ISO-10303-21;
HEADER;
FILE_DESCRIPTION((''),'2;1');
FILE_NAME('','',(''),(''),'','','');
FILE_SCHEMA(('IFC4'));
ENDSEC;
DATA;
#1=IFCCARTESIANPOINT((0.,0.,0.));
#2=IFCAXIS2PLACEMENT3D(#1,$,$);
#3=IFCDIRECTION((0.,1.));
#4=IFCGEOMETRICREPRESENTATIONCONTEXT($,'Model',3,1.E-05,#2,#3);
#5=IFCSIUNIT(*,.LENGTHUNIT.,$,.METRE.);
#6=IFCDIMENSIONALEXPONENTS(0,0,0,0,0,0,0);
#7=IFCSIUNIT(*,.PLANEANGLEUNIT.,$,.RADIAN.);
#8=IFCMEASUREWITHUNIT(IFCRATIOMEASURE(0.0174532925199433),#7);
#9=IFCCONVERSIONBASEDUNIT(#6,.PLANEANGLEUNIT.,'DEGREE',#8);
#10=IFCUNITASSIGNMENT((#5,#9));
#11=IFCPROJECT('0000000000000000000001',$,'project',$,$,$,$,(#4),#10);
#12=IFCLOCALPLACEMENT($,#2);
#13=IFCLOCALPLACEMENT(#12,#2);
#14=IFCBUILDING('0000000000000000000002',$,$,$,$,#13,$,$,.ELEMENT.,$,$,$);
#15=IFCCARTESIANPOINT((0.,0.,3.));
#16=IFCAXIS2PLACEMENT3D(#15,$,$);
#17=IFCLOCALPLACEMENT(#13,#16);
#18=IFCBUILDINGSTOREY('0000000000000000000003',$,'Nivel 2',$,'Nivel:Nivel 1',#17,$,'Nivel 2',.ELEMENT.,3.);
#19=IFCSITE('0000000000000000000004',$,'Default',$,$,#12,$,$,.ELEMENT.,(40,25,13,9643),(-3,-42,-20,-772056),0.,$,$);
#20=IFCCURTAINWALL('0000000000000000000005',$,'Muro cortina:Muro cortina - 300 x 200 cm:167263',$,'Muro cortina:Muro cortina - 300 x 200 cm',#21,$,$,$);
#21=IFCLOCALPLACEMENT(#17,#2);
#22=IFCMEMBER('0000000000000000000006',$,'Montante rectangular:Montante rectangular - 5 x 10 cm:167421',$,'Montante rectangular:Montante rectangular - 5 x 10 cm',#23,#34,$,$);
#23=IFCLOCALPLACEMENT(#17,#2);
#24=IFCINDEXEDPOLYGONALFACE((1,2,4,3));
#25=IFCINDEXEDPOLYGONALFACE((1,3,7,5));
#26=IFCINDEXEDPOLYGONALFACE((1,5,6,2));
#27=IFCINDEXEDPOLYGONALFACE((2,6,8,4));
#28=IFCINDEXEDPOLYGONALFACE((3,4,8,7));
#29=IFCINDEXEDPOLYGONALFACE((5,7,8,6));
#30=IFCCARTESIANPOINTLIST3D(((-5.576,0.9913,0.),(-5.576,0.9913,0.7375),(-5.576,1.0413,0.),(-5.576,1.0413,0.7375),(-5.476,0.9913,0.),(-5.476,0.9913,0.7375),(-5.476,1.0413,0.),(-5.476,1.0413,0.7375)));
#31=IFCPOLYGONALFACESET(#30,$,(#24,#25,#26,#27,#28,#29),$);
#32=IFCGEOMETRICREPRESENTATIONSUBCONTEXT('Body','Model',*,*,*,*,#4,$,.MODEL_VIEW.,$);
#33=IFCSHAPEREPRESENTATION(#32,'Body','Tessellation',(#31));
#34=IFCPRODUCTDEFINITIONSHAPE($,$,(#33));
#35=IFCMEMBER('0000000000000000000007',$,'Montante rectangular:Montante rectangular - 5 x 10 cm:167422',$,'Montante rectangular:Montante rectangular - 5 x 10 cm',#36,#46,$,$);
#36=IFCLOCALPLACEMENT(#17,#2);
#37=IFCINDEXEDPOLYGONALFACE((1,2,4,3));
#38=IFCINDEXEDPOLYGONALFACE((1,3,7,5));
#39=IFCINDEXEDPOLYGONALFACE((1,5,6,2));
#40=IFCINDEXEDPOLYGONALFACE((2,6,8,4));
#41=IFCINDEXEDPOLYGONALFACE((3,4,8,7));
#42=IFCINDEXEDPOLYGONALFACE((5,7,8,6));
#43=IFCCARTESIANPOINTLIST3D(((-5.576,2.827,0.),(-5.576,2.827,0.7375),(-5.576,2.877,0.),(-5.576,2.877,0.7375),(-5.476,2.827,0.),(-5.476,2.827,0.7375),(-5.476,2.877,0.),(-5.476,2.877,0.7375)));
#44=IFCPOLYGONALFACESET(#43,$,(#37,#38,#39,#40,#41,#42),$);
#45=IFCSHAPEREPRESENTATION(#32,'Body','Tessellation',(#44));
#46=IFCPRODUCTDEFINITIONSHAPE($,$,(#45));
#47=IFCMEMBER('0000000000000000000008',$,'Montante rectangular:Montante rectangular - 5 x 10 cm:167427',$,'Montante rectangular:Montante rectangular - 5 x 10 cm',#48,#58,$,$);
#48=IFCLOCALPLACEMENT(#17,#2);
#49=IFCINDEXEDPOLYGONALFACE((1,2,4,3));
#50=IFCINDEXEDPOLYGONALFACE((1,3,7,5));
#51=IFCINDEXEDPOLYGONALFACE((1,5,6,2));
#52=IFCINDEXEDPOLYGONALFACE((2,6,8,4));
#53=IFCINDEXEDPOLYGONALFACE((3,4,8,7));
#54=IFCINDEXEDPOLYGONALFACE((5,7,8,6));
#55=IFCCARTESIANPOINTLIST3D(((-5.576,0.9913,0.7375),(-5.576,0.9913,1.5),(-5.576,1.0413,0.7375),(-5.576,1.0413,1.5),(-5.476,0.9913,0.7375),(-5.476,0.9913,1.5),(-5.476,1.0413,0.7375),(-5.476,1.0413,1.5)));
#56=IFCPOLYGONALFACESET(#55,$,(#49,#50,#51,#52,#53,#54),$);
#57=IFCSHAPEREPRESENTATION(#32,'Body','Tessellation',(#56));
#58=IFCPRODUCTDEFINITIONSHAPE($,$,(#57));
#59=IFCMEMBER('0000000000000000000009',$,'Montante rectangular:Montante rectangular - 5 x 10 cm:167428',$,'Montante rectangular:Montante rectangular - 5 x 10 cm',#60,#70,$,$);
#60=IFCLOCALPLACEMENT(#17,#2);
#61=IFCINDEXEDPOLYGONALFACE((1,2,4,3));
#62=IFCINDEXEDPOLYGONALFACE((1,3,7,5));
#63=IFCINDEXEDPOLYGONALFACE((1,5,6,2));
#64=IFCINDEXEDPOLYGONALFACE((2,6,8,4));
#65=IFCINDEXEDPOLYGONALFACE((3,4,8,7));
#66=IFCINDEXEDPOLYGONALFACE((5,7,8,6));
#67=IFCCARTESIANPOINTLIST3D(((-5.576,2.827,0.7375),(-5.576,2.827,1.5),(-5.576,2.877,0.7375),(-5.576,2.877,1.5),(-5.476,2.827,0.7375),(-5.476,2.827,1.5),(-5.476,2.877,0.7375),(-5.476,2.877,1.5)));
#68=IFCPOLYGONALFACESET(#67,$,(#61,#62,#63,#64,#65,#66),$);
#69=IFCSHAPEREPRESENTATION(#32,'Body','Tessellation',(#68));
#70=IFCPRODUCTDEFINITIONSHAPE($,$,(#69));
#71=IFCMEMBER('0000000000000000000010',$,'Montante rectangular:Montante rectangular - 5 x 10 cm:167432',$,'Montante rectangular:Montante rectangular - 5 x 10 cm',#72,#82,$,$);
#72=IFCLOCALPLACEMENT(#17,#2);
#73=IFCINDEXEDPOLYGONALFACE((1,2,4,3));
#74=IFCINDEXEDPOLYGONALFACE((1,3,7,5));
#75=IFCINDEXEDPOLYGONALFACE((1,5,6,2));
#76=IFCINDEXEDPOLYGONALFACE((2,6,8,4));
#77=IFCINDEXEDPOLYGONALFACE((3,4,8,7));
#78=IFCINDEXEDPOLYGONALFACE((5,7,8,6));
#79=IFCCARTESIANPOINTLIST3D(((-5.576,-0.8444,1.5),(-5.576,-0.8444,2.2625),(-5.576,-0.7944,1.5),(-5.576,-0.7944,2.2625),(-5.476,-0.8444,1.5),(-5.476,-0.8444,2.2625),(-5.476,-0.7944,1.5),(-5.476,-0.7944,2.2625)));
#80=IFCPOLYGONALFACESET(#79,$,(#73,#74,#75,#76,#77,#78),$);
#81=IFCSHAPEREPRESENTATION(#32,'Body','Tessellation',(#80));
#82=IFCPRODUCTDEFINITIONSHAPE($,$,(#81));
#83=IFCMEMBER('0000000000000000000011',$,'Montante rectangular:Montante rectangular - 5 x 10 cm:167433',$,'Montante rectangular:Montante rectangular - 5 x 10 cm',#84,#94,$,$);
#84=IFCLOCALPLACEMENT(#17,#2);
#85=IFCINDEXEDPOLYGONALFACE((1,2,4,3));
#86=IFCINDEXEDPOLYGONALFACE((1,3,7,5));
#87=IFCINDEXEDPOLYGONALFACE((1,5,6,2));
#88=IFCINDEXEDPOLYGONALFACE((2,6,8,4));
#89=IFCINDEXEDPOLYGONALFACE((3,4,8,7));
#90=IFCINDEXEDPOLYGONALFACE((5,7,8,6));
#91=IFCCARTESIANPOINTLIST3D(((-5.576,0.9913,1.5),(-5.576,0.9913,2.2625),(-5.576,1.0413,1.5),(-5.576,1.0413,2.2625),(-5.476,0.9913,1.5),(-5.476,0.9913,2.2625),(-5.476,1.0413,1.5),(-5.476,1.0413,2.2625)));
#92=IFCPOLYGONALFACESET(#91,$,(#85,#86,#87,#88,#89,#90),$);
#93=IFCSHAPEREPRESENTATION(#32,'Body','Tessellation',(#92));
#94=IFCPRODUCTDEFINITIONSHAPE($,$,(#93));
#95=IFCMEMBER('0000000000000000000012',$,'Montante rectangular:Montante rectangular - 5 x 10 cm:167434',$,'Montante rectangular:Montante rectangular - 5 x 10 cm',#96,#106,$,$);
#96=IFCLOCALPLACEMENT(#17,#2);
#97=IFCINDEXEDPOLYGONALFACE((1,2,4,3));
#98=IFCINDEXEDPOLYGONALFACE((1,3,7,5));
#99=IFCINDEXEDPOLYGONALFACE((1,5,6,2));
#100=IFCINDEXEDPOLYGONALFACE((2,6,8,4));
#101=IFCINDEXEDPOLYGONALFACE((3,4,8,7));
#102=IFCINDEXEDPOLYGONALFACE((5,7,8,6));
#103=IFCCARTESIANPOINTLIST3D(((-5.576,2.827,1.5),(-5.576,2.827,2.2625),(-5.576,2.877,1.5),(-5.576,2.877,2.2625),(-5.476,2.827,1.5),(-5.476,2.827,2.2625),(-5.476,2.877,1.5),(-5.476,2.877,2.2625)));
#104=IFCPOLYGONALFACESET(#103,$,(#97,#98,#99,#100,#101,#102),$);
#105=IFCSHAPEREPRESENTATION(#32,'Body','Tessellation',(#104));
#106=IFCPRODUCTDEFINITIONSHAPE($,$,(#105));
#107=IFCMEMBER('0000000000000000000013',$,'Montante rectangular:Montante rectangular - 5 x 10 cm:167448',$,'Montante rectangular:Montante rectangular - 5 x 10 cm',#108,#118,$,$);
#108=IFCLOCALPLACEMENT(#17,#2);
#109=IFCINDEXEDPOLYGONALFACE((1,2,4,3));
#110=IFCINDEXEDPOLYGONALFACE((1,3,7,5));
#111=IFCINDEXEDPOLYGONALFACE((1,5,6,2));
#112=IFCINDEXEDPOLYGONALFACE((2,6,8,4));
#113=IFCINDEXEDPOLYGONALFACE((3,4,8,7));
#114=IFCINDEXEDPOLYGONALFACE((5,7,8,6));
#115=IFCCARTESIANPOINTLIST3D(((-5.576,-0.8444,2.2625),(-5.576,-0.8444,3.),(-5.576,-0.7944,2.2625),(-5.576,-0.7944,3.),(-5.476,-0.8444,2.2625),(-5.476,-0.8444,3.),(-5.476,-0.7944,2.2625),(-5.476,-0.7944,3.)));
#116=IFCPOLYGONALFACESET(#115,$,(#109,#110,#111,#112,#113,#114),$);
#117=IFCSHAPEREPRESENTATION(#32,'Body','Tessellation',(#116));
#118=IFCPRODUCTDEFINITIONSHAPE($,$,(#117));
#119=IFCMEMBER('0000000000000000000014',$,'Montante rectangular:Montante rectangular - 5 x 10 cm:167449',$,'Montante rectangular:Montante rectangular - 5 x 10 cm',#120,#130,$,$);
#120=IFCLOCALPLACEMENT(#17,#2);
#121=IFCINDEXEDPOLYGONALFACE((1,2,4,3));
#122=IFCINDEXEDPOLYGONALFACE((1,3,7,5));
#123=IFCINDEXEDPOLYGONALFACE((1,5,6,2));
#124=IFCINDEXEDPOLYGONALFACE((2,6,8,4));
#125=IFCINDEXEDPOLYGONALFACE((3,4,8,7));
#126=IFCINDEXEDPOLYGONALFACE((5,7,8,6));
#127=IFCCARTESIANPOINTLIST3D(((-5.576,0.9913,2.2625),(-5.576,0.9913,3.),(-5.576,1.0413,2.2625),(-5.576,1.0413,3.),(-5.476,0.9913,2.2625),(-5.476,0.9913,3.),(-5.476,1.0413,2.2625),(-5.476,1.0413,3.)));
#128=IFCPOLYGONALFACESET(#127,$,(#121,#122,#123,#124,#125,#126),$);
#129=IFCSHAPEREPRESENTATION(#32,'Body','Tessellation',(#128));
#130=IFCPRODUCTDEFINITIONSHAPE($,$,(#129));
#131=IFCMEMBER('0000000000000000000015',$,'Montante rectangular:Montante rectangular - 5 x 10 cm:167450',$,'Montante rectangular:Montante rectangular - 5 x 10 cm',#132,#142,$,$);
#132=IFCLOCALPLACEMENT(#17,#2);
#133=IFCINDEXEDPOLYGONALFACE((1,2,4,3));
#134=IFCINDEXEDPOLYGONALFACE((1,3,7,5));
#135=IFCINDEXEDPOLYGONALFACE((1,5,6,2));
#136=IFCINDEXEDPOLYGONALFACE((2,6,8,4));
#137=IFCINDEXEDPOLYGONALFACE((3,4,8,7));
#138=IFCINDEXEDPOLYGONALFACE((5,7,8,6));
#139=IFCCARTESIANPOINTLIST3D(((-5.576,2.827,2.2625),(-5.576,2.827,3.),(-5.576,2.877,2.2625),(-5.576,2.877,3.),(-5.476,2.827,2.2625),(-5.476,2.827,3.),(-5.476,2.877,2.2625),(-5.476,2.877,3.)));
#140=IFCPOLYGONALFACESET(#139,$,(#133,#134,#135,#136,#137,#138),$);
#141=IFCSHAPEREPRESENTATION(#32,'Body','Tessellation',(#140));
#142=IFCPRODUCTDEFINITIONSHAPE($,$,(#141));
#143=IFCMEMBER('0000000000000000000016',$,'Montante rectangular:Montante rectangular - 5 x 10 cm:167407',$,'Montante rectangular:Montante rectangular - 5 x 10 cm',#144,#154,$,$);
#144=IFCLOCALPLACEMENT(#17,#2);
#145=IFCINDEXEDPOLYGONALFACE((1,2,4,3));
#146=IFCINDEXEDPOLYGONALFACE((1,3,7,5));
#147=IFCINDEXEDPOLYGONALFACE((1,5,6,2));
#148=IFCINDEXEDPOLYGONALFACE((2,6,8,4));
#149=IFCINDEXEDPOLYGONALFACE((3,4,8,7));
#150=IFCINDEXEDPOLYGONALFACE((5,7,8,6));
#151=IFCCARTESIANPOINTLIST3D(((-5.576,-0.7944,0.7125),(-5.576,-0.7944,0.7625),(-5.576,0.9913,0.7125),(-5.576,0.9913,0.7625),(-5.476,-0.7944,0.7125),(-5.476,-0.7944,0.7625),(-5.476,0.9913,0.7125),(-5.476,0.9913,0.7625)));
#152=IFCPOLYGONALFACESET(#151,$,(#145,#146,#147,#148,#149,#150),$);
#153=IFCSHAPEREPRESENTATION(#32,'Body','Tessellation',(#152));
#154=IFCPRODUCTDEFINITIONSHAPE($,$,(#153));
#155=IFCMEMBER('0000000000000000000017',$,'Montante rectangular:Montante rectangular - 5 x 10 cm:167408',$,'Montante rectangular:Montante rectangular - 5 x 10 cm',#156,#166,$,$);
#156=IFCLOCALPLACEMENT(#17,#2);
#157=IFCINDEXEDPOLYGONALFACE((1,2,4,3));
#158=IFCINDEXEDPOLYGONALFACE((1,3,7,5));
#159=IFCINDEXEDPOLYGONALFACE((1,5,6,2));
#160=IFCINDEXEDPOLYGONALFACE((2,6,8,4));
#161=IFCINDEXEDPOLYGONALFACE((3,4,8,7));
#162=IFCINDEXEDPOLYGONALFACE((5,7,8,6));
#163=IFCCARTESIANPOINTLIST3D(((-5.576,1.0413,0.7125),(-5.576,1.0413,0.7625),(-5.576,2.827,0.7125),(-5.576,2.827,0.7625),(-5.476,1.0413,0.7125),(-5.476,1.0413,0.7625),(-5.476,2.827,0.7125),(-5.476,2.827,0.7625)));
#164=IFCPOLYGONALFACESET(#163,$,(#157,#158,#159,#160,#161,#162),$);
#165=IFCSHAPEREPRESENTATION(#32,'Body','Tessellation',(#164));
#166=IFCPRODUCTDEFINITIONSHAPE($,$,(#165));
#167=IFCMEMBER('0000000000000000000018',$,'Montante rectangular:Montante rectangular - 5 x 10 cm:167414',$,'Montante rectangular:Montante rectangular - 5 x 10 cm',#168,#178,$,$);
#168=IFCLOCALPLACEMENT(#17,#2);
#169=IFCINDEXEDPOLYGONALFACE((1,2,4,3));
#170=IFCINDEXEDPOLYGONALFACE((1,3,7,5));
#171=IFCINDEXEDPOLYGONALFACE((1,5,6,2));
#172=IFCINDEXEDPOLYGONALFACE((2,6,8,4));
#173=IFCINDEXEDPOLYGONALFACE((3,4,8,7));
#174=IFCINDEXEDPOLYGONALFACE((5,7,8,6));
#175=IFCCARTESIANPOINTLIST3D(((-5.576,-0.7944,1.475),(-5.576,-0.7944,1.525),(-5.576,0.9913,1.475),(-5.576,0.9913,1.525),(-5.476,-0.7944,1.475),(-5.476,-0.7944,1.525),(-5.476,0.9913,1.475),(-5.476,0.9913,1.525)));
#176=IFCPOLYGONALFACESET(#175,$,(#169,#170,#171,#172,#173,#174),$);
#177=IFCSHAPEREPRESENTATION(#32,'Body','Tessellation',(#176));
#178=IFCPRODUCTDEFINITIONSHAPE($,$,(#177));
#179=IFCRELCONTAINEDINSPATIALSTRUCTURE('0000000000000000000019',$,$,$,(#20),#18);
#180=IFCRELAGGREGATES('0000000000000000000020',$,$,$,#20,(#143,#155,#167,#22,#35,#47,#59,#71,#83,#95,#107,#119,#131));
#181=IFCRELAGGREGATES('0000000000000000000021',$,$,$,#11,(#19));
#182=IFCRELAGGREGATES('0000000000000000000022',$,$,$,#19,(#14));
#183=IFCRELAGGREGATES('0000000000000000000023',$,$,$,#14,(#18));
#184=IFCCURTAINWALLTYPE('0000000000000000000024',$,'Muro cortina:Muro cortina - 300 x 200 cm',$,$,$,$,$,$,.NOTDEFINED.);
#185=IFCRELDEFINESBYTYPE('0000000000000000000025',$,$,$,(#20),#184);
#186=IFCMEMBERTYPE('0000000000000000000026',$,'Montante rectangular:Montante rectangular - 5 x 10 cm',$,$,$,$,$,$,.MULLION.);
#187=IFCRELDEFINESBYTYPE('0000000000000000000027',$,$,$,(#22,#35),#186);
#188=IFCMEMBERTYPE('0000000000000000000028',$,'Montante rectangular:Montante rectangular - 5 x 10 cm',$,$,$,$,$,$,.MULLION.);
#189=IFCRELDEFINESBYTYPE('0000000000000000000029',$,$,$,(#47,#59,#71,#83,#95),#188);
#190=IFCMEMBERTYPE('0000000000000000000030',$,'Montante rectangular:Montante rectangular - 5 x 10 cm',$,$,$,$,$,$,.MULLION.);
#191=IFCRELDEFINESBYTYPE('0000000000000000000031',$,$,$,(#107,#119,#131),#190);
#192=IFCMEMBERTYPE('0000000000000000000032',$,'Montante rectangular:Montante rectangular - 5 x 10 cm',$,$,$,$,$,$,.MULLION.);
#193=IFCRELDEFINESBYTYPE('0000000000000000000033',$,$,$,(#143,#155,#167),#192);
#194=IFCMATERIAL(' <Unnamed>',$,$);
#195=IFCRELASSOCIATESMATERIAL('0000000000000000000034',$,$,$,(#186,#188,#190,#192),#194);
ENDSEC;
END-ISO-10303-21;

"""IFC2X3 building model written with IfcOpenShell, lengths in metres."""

from ifc_helpers import new_model, entity, si_unit, converted_unit, direction, frame, origin, origin_2d_with_axis, place, context, subcontext, project, spatial, rectangle, extrude, source, transform, mapped, material, type_object, type_shapes, element, aggregate, save


model = new_model("IFC2X3")

# Units and contexts
model_context = context("Model", 3, precision=1e-05, world=origin(), true_north=direction((0.0, 1.0)))
body_context = subcontext(model_context, "Body", "Model", "MODEL_VIEW")
ifc_project = project(units=[si_unit("LENGTHUNIT", "METRE"), converted_unit("PLANEANGLEUNIT", "DEGREE", entity("IfcRatioMeasure", 0.0174532925199433), si_unit("PLANEANGLEUNIT", "RADIAN"), dimensions=[0, 0, 0, 0, 0, 0, 0])], contexts=[model_context])

# Site, building, storey
site_placement = place(None, origin())
site = spatial("IfcSite", under=ifc_project, at=site_placement, Name="Default", CompositionType="ELEMENT", RefLatitude=(40, 25, 13, 9643), RefLongitude=(-3, -42, -20, -772056), RefElevation=0.0)
building_placement = place(site_placement, origin())
building = spatial("IfcBuilding", under=site, at=building_placement, CompositionType="ELEMENT")
storey_placement = place(building_placement, frame((0.0, 0.0, 3.0)))
storey = spatial("IfcBuildingStorey", under=building, at=storey_placement, Name="Nivel 2", ObjectType="Nivel:Nivel 1", LongName="Nivel 2", CompositionType="ELEMENT", Elevation=3.0)

# Curtain wall, members
curtain_wall_type = type_object("IfcCurtainWallType", Name="Muro cortina:Muro cortina - 300 x 200 cm", PredefinedType="NOTDEFINED")
curtain_wall_placement = place(storey_placement, frame((0.0, 0.0, -3.0)))
curtain_wall = element("IfcCurtainWall", 1, at=curtain_wall_placement, inside=storey, type_object=curtain_wall_type, Name="Muro cortina:Muro cortina - 300 x 200 cm:167263", ObjectType="Muro cortina:Muro cortina - 300 x 200 cm")
ifc_material_1 = material(Name=" <Unnamed>")
member_type_1 = type_object("IfcMemberType", Name="Montante rectangular:Montante rectangular - 5 x 10 cm", PredefinedType="MULLION", material=ifc_material_1)
shared_shape_1 = source(origin(), body_context, "Body", "SweptSolid", [
    extrude(rectangle(XDim=0.1, YDim=0.05, at=origin_2d_with_axis()), frame((0.0, 0.0, -0.7375), z_axis=(0.0, 0.0, 1.0), x_axis=(0.0, -1.0, 0.0)), (0.0, 0.0, 1.0), 0.7375),
])
type_shapes(member_type_1, [shared_shape_1])
member_1_placement = place(storey_placement, frame((-5.526, 1.0163, 0.0), z_axis=(0.0, 0.0, -1.0), x_axis=(0.0, 1.0, 0.0)))
member_1 = element("IfcMember", 2, at=member_1_placement, type_object=member_type_1, Name="Montante rectangular:Montante rectangular - 5 x 10 cm:167421", ObjectType="Montante rectangular:Montante rectangular - 5 x 10 cm", context=body_context, shape_type="MappedRepresentation", body=[
    mapped(shared_shape_1, transform((0.0, 0.0, 0.0), scale=1.0)),
])
member_2_placement = place(storey_placement, frame((-5.526, 2.852, 0.0), z_axis=(0.0, 0.0, -1.0), x_axis=(0.0, 1.0, 0.0)))
member_2 = element("IfcMember", 3, at=member_2_placement, type_object=member_type_1, Name="Montante rectangular:Montante rectangular - 5 x 10 cm:167422", ObjectType="Montante rectangular:Montante rectangular - 5 x 10 cm", context=body_context, shape_type="MappedRepresentation", body=[
    mapped(shared_shape_1, transform((0.0, 0.0, 0.0), scale=1.0)),
])
member_type_2 = type_object("IfcMemberType", Name="Montante rectangular:Montante rectangular - 5 x 10 cm", PredefinedType="MULLION", material=ifc_material_1)
shared_shape_2 = source(origin(), body_context, "Body", "SweptSolid", [
    extrude(rectangle(XDim=0.1, YDim=0.05, at=origin_2d_with_axis()), frame((0.0, 0.0, -0.7625), z_axis=(0.0, 0.0, 1.0), x_axis=(0.0, -1.0, 0.0)), (0.0, 0.0, 1.0), 0.7625),
])
type_shapes(member_type_2, [shared_shape_2])
member_3_placement = place(storey_placement, frame((-5.526, 1.0163, 0.7375), z_axis=(0.0, 0.0, -1.0), x_axis=(0.0, 1.0, 0.0)))
member_3 = element("IfcMember", 4, at=member_3_placement, type_object=member_type_2, Name="Montante rectangular:Montante rectangular - 5 x 10 cm:167427", ObjectType="Montante rectangular:Montante rectangular - 5 x 10 cm", context=body_context, shape_type="MappedRepresentation", body=[
    mapped(shared_shape_2, transform((0.0, 0.0, 0.0), scale=1.0)),
])
member_4_placement = place(storey_placement, frame((-5.526, 2.852, 0.7375), z_axis=(0.0, 0.0, -1.0), x_axis=(0.0, 1.0, 0.0)))
member_4 = element("IfcMember", 5, at=member_4_placement, type_object=member_type_2, Name="Montante rectangular:Montante rectangular - 5 x 10 cm:167428", ObjectType="Montante rectangular:Montante rectangular - 5 x 10 cm", context=body_context, shape_type="MappedRepresentation", body=[
    mapped(shared_shape_2, transform((0.0, 0.0, 0.0), scale=1.0)),
])
member_5_placement = place(storey_placement, frame((-5.526, -0.8194, 1.5), z_axis=(0.0, 0.0, -1.0), x_axis=(0.0, 1.0, 0.0)))
member_5 = element("IfcMember", 6, at=member_5_placement, type_object=member_type_2, Name="Montante rectangular:Montante rectangular - 5 x 10 cm:167432", ObjectType="Montante rectangular:Montante rectangular - 5 x 10 cm", context=body_context, shape_type="MappedRepresentation", body=[
    mapped(shared_shape_2, transform((0.0, 0.0, 0.0), scale=1.0)),
])
member_6_placement = place(storey_placement, frame((-5.526, 1.0163, 1.5), z_axis=(0.0, 0.0, -1.0), x_axis=(0.0, 1.0, 0.0)))
member_6 = element("IfcMember", 7, at=member_6_placement, type_object=member_type_2, Name="Montante rectangular:Montante rectangular - 5 x 10 cm:167433", ObjectType="Montante rectangular:Montante rectangular - 5 x 10 cm", context=body_context, shape_type="MappedRepresentation", body=[
    mapped(shared_shape_2, transform((0.0, 0.0, 0.0), scale=1.0)),
])
member_7_placement = place(storey_placement, frame((-5.526, 2.852, 1.5), z_axis=(0.0, 0.0, -1.0), x_axis=(0.0, 1.0, 0.0)))
member_7 = element("IfcMember", 8, at=member_7_placement, type_object=member_type_2, Name="Montante rectangular:Montante rectangular - 5 x 10 cm:167434", ObjectType="Montante rectangular:Montante rectangular - 5 x 10 cm", context=body_context, shape_type="MappedRepresentation", body=[
    mapped(shared_shape_2, transform((0.0, 0.0, 0.0), scale=1.0)),
])
member_type_3 = type_object("IfcMemberType", Name="Montante rectangular:Montante rectangular - 5 x 10 cm", PredefinedType="MULLION", material=ifc_material_1)
shared_shape_3 = source(origin(), body_context, "Body", "SweptSolid", [
    extrude(rectangle(XDim=0.1, YDim=0.05, at=origin_2d_with_axis()), frame((0.0, 0.0, -0.7375), z_axis=(0.0, 0.0, 1.0), x_axis=(0.0, -1.0, 0.0)), (0.0, 0.0, 1.0), 0.7375),
])
type_shapes(member_type_3, [shared_shape_3])
member_8_placement = place(storey_placement, frame((-5.526, -0.8194, 2.2625), z_axis=(0.0, 0.0, -1.0), x_axis=(0.0, 1.0, 0.0)))
member_8 = element("IfcMember", 9, at=member_8_placement, type_object=member_type_3, Name="Montante rectangular:Montante rectangular - 5 x 10 cm:167448", ObjectType="Montante rectangular:Montante rectangular - 5 x 10 cm", context=body_context, shape_type="MappedRepresentation", body=[
    mapped(shared_shape_3, transform((0.0, 0.0, 0.0), scale=1.0)),
])
member_9_placement = place(storey_placement, frame((-5.526, 1.0163, 2.2625), z_axis=(0.0, 0.0, -1.0), x_axis=(0.0, 1.0, 0.0)))
member_9 = element("IfcMember", 10, at=member_9_placement, type_object=member_type_3, Name="Montante rectangular:Montante rectangular - 5 x 10 cm:167449", ObjectType="Montante rectangular:Montante rectangular - 5 x 10 cm", context=body_context, shape_type="MappedRepresentation", body=[
    mapped(shared_shape_3, transform((0.0, 0.0, 0.0), scale=1.0)),
])
member_10_placement = place(storey_placement, frame((-5.526, 2.852, 2.2625), z_axis=(0.0, 0.0, -1.0), x_axis=(0.0, 1.0, 0.0)))
member_10 = element("IfcMember", 11, at=member_10_placement, type_object=member_type_3, Name="Montante rectangular:Montante rectangular - 5 x 10 cm:167450", ObjectType="Montante rectangular:Montante rectangular - 5 x 10 cm", context=body_context, shape_type="MappedRepresentation", body=[
    mapped(shared_shape_3, transform((0.0, 0.0, 0.0), scale=1.0)),
])
member_type_4 = type_object("IfcMemberType", Name="Montante rectangular:Montante rectangular - 5 x 10 cm", PredefinedType="MULLION", material=ifc_material_1)
shared_shape_4 = source(origin(), body_context, "Body", "SweptSolid", [
    extrude(rectangle(XDim=0.1, YDim=0.05, at=origin_2d_with_axis()), frame((0.0, 0.0, -1.7857), z_axis=(0.0, 0.0, 1.0), x_axis=(0.0, -1.0, 0.0)), (0.0, 0.0, 1.0), 1.7857),
])
type_shapes(member_type_4, [shared_shape_4])
member_11_placement = place(storey_placement, frame((-5.526, 0.9913, 0.7375), z_axis=(0.0, 1.0, 0.0), x_axis=(0.0, 0.0, 1.0)))
member_11 = element("IfcMember", 12, at=member_11_placement, type_object=member_type_4, Name="Montante rectangular:Montante rectangular - 5 x 10 cm:167407", ObjectType="Montante rectangular:Montante rectangular - 5 x 10 cm", context=body_context, shape_type="MappedRepresentation", body=[
    mapped(shared_shape_4, transform((0.0, 0.0, 0.0), scale=1.0)),
])
member_12_placement = place(storey_placement, frame((-5.526, 2.827, 0.7375), z_axis=(0.0, 1.0, 0.0), x_axis=(0.0, 0.0, 1.0)))
member_12 = element("IfcMember", 13, at=member_12_placement, type_object=member_type_4, Name="Montante rectangular:Montante rectangular - 5 x 10 cm:167408", ObjectType="Montante rectangular:Montante rectangular - 5 x 10 cm", context=body_context, shape_type="MappedRepresentation", body=[
    mapped(shared_shape_4, transform((0.0, 0.0, 0.0), scale=1.0)),
])
member_13_placement = place(storey_placement, frame((-5.526, 0.9913, 1.5), z_axis=(0.0, 1.0, 0.0), x_axis=(0.0, 0.0, 1.0)))
member_13 = element("IfcMember", 14, at=member_13_placement, type_object=member_type_4, Name="Montante rectangular:Montante rectangular - 5 x 10 cm:167414", ObjectType="Montante rectangular:Montante rectangular - 5 x 10 cm", context=body_context, shape_type="MappedRepresentation", body=[
    mapped(shared_shape_4, transform((0.0, 0.0, 0.0), scale=1.0)),
])
aggregate(curtain_wall, [member_11, member_12, member_13, member_1, member_2, member_3, member_4, member_5, member_6, member_7, member_8, member_9, member_10])

save(model, "model.ifc")
